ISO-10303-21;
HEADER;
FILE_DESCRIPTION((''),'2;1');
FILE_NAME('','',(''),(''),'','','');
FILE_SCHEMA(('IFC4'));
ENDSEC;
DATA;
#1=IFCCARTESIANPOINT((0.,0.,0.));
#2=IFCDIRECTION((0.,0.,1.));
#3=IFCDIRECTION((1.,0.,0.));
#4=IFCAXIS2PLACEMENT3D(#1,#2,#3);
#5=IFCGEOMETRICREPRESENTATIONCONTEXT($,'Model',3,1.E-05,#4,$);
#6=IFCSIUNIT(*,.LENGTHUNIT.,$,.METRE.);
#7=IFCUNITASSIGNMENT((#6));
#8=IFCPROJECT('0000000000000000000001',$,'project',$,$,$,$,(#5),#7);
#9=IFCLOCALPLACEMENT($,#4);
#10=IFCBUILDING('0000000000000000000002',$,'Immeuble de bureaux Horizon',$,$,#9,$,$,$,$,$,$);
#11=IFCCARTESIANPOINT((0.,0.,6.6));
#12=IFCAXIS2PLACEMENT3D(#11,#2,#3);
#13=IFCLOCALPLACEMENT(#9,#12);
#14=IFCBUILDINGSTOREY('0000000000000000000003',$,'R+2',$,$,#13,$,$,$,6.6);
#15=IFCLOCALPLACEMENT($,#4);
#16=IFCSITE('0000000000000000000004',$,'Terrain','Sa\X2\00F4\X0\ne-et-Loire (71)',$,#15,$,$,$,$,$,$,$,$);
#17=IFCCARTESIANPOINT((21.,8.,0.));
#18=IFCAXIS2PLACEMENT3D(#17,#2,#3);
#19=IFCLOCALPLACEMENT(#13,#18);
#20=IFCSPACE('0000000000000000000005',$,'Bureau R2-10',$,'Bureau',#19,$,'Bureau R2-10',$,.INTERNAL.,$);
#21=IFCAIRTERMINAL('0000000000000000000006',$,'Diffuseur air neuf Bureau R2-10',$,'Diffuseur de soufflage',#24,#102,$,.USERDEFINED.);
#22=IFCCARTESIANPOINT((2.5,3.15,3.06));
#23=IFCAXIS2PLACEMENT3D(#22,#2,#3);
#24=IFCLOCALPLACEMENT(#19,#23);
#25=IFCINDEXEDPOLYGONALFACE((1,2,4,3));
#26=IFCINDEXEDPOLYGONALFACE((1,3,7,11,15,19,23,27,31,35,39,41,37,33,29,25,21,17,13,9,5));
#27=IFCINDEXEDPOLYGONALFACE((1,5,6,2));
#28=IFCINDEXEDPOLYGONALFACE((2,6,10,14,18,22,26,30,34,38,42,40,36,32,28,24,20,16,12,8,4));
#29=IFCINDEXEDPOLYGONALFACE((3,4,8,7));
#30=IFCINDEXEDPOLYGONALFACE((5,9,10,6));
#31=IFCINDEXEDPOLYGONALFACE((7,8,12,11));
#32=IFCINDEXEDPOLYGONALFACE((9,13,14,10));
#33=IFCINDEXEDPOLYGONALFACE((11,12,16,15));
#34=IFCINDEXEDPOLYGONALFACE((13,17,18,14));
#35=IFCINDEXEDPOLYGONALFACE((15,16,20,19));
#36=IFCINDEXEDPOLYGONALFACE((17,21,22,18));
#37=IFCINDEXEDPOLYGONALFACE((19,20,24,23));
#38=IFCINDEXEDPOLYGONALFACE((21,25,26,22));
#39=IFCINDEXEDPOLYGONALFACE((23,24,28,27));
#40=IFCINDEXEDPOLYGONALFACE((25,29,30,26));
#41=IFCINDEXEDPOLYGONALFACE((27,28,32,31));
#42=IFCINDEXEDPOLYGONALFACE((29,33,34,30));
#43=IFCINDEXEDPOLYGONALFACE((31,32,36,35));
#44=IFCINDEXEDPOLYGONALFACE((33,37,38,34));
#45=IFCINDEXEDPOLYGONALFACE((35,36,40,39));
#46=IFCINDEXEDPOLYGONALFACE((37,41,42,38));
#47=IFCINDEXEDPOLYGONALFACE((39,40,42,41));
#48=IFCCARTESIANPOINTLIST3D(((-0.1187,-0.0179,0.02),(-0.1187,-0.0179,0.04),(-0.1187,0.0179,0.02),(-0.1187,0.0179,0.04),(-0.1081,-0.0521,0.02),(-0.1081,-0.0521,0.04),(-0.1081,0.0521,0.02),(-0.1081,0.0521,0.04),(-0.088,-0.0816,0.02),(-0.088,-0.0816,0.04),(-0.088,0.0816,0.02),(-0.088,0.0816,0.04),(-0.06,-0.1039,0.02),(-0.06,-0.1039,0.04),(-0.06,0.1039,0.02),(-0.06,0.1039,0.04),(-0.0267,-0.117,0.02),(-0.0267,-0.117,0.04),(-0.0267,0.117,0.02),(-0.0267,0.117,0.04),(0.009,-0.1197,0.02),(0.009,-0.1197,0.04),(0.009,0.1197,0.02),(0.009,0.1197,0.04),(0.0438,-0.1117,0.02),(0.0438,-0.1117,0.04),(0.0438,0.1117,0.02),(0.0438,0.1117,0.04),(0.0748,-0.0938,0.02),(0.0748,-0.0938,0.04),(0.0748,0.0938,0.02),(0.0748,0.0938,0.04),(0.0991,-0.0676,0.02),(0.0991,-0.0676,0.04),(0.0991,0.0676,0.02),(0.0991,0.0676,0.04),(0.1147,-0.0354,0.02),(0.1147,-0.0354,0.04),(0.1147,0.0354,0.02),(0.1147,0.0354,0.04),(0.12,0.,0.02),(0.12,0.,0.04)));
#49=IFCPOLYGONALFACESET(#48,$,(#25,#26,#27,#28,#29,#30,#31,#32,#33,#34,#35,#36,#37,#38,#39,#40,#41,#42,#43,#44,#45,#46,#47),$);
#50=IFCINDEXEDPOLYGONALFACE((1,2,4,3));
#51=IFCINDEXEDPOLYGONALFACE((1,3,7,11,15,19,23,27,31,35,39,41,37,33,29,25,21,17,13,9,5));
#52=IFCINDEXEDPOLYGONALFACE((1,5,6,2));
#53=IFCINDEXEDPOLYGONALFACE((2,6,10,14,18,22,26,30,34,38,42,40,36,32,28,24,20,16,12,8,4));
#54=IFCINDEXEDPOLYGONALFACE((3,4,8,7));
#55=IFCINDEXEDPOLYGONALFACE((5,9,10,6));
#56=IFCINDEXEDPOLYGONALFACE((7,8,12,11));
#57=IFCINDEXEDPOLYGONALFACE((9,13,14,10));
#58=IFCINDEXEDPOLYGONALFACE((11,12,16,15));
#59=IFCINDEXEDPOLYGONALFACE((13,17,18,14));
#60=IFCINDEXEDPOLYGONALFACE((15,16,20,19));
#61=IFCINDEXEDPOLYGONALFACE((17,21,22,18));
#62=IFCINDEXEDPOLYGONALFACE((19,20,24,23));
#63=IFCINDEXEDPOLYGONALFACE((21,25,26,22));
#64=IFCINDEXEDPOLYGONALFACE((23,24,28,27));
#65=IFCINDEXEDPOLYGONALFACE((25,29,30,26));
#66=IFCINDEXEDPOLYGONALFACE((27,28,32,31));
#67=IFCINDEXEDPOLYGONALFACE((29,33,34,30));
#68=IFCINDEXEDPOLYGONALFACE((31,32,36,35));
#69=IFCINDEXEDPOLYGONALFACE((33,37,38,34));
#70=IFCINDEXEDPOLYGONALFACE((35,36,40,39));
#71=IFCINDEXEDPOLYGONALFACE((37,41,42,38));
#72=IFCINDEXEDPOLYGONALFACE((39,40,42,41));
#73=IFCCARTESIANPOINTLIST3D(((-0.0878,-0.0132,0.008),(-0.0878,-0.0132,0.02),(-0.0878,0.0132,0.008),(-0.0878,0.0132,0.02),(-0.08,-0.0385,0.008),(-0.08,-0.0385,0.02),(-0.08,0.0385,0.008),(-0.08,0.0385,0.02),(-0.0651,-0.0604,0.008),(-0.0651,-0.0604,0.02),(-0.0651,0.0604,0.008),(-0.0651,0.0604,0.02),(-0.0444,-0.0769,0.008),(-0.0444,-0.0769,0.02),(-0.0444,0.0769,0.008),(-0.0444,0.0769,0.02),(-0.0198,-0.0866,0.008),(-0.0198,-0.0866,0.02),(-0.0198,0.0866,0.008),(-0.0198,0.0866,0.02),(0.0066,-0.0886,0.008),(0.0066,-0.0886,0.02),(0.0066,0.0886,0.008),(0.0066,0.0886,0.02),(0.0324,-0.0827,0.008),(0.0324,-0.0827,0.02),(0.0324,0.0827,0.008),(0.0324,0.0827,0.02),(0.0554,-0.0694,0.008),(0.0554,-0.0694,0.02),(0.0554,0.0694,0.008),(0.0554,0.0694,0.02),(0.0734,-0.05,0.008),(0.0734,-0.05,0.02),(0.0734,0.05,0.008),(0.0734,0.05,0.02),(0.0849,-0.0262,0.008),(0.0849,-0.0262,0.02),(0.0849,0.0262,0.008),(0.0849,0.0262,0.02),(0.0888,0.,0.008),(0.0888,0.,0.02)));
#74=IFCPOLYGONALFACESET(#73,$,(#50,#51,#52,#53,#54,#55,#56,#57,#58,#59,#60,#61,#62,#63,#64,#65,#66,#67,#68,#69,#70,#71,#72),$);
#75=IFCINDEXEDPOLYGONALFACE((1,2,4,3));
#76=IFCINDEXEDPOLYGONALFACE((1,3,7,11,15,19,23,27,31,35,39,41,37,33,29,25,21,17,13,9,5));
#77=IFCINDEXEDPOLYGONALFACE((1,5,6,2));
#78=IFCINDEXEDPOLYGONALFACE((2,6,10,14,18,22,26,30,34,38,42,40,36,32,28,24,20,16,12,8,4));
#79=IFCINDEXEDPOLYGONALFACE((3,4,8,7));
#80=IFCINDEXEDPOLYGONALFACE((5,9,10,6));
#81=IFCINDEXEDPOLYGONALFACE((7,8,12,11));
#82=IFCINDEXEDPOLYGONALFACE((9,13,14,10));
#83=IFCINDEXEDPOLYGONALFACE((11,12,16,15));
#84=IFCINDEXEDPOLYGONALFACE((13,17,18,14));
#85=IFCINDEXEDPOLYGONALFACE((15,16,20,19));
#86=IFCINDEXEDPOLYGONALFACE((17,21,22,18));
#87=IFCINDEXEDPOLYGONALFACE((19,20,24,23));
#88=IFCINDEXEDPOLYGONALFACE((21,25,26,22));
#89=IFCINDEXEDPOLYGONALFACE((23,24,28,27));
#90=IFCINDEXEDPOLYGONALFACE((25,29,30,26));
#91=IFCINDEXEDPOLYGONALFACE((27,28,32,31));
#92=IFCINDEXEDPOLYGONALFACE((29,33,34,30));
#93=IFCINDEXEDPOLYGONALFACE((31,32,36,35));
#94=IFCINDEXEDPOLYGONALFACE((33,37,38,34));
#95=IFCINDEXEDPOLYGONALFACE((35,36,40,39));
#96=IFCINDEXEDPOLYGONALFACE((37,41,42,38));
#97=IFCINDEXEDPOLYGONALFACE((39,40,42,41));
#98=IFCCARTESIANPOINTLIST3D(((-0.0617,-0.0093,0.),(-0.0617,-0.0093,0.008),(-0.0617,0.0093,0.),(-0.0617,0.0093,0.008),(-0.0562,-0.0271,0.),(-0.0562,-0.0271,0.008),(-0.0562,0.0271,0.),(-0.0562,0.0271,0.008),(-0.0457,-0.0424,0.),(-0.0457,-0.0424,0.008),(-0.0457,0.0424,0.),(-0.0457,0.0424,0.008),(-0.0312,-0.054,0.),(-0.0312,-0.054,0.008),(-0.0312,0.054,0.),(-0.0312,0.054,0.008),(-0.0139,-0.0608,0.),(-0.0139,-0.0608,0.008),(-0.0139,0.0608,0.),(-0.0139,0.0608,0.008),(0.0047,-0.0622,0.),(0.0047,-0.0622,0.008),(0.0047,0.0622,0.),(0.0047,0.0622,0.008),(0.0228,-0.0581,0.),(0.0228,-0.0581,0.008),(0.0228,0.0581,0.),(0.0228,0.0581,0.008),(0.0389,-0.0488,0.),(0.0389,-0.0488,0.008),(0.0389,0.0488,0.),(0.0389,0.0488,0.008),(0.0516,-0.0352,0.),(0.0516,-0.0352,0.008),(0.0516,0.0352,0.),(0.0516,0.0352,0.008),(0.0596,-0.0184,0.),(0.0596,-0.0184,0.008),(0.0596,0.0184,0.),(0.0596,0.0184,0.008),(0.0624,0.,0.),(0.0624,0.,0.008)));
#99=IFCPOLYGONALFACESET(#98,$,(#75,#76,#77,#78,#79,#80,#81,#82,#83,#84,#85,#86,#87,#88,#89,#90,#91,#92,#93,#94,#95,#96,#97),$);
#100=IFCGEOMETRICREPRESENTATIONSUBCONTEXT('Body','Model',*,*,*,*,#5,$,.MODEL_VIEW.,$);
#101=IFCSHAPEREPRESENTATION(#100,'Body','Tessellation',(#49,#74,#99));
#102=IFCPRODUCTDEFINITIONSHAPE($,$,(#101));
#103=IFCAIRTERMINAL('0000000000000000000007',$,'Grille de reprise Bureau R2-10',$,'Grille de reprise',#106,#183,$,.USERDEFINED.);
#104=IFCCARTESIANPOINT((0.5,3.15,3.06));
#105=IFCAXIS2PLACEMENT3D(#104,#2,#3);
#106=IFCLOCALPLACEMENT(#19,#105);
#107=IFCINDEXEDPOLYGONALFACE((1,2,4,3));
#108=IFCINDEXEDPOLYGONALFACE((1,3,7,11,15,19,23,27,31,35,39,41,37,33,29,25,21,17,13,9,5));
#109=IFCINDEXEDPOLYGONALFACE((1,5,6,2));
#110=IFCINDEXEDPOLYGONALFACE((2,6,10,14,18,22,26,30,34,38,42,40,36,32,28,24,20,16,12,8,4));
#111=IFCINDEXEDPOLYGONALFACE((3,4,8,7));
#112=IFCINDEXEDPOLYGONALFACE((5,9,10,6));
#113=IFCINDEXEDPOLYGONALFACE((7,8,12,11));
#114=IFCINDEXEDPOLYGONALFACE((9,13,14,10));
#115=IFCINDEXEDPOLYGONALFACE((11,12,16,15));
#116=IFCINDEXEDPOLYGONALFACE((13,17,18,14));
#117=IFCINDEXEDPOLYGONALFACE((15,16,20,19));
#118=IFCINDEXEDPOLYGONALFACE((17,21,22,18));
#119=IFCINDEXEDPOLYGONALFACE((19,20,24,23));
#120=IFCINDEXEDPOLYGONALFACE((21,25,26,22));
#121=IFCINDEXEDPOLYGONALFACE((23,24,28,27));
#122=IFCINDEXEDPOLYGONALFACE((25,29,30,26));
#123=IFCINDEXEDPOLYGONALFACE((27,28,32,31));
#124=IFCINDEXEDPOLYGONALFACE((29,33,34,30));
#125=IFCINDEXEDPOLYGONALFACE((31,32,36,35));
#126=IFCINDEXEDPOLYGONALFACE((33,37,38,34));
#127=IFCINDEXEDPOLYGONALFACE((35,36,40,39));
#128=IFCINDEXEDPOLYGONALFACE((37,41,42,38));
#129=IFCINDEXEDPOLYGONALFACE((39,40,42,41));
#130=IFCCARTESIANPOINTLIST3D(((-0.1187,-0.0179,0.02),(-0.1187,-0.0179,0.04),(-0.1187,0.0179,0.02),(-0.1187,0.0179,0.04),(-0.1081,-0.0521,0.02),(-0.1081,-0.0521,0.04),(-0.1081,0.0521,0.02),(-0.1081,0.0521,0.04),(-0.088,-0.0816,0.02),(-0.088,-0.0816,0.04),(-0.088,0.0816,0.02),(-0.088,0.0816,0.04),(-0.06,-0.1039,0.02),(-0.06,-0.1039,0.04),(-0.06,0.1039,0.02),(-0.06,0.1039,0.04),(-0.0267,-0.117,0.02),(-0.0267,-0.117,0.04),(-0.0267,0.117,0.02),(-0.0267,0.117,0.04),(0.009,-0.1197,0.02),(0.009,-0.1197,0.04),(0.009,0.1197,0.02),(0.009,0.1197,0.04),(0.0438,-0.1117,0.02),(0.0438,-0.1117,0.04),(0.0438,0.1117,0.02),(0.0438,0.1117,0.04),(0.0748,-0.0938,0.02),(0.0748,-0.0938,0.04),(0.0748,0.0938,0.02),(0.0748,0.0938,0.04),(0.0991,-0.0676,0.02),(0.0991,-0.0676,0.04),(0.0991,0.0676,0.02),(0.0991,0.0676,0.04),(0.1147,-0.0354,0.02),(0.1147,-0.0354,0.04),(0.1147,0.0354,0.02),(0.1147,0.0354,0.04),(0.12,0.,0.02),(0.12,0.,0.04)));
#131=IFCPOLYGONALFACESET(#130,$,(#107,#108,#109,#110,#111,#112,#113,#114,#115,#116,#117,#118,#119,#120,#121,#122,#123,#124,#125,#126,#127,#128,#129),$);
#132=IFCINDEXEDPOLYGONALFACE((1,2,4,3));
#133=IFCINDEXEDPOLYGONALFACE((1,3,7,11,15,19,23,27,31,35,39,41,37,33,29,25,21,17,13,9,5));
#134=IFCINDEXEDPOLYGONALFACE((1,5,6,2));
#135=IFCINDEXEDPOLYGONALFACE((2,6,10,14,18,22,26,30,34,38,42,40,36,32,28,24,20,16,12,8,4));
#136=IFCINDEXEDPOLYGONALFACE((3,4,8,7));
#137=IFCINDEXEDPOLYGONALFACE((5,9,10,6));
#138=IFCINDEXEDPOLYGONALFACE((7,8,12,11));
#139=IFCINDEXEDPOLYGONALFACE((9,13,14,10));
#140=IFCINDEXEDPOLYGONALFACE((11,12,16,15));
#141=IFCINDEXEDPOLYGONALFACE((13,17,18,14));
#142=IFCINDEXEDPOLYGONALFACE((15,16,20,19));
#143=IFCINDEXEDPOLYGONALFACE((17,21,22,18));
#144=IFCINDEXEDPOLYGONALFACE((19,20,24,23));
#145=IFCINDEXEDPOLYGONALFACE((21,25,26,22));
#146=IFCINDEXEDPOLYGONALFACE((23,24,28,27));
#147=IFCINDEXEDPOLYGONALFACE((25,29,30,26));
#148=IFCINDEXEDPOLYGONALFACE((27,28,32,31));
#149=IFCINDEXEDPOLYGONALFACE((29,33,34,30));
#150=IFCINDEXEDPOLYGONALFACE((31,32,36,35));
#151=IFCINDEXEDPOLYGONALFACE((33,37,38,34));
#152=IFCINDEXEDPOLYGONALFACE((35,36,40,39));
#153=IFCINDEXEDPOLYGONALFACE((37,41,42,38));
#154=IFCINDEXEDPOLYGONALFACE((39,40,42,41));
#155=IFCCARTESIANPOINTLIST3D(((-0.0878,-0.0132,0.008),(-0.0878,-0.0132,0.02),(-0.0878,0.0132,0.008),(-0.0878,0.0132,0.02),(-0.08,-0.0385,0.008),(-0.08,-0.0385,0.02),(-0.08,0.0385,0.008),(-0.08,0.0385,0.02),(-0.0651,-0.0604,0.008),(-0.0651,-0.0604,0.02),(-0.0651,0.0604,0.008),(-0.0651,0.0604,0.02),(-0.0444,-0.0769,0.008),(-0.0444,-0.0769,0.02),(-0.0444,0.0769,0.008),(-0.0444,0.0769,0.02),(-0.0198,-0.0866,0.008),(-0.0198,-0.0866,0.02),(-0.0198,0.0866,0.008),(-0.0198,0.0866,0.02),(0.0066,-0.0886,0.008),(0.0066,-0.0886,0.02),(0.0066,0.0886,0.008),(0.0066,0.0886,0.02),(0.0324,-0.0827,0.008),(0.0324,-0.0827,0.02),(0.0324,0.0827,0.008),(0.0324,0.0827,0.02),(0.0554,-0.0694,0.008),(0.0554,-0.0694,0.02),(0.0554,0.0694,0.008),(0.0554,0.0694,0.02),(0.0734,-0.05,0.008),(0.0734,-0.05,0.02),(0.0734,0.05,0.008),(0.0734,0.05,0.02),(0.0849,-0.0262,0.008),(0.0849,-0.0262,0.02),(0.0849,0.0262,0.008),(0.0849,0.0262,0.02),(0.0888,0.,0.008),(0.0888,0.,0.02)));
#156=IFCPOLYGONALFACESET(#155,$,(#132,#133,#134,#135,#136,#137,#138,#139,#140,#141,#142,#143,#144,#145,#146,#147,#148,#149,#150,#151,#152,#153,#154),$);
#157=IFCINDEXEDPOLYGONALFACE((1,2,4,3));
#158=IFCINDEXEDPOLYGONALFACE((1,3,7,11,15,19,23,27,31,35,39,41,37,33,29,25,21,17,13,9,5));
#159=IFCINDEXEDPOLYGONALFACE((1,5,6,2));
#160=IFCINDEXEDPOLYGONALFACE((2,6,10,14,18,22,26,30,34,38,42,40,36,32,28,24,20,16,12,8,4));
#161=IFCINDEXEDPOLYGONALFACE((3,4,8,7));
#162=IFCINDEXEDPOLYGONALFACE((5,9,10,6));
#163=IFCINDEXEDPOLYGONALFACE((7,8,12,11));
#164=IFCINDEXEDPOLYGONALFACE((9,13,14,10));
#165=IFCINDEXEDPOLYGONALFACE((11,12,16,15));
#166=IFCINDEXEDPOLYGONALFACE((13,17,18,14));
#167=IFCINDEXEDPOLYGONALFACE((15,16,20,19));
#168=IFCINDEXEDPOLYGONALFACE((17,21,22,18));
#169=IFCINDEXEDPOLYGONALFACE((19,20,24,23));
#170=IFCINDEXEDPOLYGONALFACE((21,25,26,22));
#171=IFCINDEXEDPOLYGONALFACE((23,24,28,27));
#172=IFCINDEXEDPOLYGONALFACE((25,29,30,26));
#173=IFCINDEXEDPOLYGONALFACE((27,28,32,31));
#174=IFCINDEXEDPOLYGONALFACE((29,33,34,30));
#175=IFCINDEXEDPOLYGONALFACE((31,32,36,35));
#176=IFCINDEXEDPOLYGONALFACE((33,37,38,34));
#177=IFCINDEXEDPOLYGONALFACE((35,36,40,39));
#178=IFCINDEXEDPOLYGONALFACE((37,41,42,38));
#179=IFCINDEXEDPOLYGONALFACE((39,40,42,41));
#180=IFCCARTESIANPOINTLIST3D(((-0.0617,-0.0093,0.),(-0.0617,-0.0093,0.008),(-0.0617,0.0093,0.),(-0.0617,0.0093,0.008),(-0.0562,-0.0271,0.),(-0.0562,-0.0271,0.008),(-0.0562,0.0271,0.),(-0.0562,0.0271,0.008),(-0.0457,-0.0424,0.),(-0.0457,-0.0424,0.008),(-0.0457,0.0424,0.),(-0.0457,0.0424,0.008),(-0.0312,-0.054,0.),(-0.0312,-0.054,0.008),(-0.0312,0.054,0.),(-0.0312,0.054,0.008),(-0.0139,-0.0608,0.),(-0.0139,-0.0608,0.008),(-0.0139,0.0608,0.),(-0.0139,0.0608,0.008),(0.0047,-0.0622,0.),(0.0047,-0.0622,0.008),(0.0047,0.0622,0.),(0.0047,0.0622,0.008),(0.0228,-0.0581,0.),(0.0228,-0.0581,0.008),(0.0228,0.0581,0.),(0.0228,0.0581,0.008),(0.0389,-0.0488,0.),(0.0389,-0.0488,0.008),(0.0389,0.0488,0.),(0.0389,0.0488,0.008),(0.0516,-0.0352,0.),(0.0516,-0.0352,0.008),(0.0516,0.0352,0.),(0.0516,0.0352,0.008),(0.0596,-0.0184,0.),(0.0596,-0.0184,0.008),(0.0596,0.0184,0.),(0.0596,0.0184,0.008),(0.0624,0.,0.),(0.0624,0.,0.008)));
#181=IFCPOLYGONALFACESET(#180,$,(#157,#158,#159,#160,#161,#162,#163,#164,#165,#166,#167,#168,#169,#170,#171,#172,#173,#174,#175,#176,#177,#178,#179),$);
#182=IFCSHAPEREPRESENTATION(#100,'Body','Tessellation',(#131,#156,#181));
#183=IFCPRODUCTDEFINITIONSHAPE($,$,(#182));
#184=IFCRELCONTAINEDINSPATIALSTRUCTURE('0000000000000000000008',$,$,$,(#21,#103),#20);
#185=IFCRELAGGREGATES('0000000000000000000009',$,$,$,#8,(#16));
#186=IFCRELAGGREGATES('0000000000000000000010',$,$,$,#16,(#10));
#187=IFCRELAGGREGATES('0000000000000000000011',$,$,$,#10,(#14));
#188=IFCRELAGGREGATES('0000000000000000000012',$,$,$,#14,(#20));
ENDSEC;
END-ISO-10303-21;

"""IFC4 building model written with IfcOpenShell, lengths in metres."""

from ifc_helpers import new_model, si_unit, frame, origin_with_axes, place, context, subcontext, project, spatial, circle, extrude, element, save


model = new_model("IFC4")

# Units and contexts
model_context = context("Model", 3, precision=1e-05, world=origin_with_axes())
body_context = subcontext(model_context, "Body", "Model", "MODEL_VIEW")
ifc_project = project(units=[si_unit("LENGTHUNIT", "METRE")], contexts=[model_context])

# Site, building, storey
site_placement = place(None, origin_with_axes())
site = spatial("IfcSite", under=ifc_project, at=site_placement, Name="Terrain", Description="Saône-et-Loire (71)")
building_placement = place(None, origin_with_axes())
building = spatial("IfcBuilding", under=site, at=building_placement, Name="Immeuble de bureaux Horizon")
storey_placement = place(building_placement, frame((0.0, 0.0, 6.6), z_axis=(0.0, 0.0, 1.0), x_axis=(1.0, 0.0, 0.0)))
storey = spatial("IfcBuildingStorey", under=building, at=storey_placement, Name="R+2", Elevation=6.6)

# Shared definitions
space_1_placement = place(storey_placement, frame((21.0, 8.0, 0.0), z_axis=(0.0, 0.0, 1.0), x_axis=(1.0, 0.0, 0.0)))
space_1 = spatial("IfcSpace", under=storey, at=space_1_placement, Name="Bureau R2-10", ObjectType="Bureau", LongName="Bureau R2-10", PredefinedType="INTERNAL")

# Air terminal
air_terminal_1_placement = place(space_1_placement, frame((2.5, 3.15, 3.06), z_axis=(0.0, 0.0, 1.0), x_axis=(1.0, 0.0, 0.0)))
element("IfcAirTerminal", 1, at=air_terminal_1_placement, inside=space_1, Name="Diffuseur air neuf Bureau R2-10", ObjectType="Diffuseur de soufflage", PredefinedType="USERDEFINED", context=body_context, shape_type="SweptSolid", body=[
    extrude(circle(Radius=0.12), frame((0.0, 0.0, 0.02), z_axis=(0.0, 0.0, 1.0), x_axis=(1.0, 0.0, 0.0)), (0.0, 0.0, 1.0), 0.02),
    extrude(circle(Radius=0.0888), frame((0.0, 0.0, 0.008), z_axis=(0.0, 0.0, 1.0), x_axis=(1.0, 0.0, 0.0)), (0.0, 0.0, 1.0), 0.012),
    extrude(circle(Radius=0.0624), origin_with_axes(), (0.0, 0.0, 1.0), 0.008),
])

# Air terminal
air_terminal_2_placement = place(space_1_placement, frame((0.5, 3.15, 3.06), z_axis=(0.0, 0.0, 1.0), x_axis=(1.0, 0.0, 0.0)))
element("IfcAirTerminal", 2, at=air_terminal_2_placement, inside=space_1, Name="Grille de reprise Bureau R2-10", ObjectType="Grille de reprise", PredefinedType="USERDEFINED", context=body_context, shape_type="SweptSolid", body=[
    extrude(circle(Radius=0.12), frame((0.0, 0.0, 0.02), z_axis=(0.0, 0.0, 1.0), x_axis=(1.0, 0.0, 0.0)), (0.0, 0.0, 1.0), 0.02),
    extrude(circle(Radius=0.0888), frame((0.0, 0.0, 0.008), z_axis=(0.0, 0.0, 1.0), x_axis=(1.0, 0.0, 0.0)), (0.0, 0.0, 1.0), 0.012),
    extrude(circle(Radius=0.0624), origin_with_axes(), (0.0, 0.0, 1.0), 0.008),
])

save(model, "model.ifc")
